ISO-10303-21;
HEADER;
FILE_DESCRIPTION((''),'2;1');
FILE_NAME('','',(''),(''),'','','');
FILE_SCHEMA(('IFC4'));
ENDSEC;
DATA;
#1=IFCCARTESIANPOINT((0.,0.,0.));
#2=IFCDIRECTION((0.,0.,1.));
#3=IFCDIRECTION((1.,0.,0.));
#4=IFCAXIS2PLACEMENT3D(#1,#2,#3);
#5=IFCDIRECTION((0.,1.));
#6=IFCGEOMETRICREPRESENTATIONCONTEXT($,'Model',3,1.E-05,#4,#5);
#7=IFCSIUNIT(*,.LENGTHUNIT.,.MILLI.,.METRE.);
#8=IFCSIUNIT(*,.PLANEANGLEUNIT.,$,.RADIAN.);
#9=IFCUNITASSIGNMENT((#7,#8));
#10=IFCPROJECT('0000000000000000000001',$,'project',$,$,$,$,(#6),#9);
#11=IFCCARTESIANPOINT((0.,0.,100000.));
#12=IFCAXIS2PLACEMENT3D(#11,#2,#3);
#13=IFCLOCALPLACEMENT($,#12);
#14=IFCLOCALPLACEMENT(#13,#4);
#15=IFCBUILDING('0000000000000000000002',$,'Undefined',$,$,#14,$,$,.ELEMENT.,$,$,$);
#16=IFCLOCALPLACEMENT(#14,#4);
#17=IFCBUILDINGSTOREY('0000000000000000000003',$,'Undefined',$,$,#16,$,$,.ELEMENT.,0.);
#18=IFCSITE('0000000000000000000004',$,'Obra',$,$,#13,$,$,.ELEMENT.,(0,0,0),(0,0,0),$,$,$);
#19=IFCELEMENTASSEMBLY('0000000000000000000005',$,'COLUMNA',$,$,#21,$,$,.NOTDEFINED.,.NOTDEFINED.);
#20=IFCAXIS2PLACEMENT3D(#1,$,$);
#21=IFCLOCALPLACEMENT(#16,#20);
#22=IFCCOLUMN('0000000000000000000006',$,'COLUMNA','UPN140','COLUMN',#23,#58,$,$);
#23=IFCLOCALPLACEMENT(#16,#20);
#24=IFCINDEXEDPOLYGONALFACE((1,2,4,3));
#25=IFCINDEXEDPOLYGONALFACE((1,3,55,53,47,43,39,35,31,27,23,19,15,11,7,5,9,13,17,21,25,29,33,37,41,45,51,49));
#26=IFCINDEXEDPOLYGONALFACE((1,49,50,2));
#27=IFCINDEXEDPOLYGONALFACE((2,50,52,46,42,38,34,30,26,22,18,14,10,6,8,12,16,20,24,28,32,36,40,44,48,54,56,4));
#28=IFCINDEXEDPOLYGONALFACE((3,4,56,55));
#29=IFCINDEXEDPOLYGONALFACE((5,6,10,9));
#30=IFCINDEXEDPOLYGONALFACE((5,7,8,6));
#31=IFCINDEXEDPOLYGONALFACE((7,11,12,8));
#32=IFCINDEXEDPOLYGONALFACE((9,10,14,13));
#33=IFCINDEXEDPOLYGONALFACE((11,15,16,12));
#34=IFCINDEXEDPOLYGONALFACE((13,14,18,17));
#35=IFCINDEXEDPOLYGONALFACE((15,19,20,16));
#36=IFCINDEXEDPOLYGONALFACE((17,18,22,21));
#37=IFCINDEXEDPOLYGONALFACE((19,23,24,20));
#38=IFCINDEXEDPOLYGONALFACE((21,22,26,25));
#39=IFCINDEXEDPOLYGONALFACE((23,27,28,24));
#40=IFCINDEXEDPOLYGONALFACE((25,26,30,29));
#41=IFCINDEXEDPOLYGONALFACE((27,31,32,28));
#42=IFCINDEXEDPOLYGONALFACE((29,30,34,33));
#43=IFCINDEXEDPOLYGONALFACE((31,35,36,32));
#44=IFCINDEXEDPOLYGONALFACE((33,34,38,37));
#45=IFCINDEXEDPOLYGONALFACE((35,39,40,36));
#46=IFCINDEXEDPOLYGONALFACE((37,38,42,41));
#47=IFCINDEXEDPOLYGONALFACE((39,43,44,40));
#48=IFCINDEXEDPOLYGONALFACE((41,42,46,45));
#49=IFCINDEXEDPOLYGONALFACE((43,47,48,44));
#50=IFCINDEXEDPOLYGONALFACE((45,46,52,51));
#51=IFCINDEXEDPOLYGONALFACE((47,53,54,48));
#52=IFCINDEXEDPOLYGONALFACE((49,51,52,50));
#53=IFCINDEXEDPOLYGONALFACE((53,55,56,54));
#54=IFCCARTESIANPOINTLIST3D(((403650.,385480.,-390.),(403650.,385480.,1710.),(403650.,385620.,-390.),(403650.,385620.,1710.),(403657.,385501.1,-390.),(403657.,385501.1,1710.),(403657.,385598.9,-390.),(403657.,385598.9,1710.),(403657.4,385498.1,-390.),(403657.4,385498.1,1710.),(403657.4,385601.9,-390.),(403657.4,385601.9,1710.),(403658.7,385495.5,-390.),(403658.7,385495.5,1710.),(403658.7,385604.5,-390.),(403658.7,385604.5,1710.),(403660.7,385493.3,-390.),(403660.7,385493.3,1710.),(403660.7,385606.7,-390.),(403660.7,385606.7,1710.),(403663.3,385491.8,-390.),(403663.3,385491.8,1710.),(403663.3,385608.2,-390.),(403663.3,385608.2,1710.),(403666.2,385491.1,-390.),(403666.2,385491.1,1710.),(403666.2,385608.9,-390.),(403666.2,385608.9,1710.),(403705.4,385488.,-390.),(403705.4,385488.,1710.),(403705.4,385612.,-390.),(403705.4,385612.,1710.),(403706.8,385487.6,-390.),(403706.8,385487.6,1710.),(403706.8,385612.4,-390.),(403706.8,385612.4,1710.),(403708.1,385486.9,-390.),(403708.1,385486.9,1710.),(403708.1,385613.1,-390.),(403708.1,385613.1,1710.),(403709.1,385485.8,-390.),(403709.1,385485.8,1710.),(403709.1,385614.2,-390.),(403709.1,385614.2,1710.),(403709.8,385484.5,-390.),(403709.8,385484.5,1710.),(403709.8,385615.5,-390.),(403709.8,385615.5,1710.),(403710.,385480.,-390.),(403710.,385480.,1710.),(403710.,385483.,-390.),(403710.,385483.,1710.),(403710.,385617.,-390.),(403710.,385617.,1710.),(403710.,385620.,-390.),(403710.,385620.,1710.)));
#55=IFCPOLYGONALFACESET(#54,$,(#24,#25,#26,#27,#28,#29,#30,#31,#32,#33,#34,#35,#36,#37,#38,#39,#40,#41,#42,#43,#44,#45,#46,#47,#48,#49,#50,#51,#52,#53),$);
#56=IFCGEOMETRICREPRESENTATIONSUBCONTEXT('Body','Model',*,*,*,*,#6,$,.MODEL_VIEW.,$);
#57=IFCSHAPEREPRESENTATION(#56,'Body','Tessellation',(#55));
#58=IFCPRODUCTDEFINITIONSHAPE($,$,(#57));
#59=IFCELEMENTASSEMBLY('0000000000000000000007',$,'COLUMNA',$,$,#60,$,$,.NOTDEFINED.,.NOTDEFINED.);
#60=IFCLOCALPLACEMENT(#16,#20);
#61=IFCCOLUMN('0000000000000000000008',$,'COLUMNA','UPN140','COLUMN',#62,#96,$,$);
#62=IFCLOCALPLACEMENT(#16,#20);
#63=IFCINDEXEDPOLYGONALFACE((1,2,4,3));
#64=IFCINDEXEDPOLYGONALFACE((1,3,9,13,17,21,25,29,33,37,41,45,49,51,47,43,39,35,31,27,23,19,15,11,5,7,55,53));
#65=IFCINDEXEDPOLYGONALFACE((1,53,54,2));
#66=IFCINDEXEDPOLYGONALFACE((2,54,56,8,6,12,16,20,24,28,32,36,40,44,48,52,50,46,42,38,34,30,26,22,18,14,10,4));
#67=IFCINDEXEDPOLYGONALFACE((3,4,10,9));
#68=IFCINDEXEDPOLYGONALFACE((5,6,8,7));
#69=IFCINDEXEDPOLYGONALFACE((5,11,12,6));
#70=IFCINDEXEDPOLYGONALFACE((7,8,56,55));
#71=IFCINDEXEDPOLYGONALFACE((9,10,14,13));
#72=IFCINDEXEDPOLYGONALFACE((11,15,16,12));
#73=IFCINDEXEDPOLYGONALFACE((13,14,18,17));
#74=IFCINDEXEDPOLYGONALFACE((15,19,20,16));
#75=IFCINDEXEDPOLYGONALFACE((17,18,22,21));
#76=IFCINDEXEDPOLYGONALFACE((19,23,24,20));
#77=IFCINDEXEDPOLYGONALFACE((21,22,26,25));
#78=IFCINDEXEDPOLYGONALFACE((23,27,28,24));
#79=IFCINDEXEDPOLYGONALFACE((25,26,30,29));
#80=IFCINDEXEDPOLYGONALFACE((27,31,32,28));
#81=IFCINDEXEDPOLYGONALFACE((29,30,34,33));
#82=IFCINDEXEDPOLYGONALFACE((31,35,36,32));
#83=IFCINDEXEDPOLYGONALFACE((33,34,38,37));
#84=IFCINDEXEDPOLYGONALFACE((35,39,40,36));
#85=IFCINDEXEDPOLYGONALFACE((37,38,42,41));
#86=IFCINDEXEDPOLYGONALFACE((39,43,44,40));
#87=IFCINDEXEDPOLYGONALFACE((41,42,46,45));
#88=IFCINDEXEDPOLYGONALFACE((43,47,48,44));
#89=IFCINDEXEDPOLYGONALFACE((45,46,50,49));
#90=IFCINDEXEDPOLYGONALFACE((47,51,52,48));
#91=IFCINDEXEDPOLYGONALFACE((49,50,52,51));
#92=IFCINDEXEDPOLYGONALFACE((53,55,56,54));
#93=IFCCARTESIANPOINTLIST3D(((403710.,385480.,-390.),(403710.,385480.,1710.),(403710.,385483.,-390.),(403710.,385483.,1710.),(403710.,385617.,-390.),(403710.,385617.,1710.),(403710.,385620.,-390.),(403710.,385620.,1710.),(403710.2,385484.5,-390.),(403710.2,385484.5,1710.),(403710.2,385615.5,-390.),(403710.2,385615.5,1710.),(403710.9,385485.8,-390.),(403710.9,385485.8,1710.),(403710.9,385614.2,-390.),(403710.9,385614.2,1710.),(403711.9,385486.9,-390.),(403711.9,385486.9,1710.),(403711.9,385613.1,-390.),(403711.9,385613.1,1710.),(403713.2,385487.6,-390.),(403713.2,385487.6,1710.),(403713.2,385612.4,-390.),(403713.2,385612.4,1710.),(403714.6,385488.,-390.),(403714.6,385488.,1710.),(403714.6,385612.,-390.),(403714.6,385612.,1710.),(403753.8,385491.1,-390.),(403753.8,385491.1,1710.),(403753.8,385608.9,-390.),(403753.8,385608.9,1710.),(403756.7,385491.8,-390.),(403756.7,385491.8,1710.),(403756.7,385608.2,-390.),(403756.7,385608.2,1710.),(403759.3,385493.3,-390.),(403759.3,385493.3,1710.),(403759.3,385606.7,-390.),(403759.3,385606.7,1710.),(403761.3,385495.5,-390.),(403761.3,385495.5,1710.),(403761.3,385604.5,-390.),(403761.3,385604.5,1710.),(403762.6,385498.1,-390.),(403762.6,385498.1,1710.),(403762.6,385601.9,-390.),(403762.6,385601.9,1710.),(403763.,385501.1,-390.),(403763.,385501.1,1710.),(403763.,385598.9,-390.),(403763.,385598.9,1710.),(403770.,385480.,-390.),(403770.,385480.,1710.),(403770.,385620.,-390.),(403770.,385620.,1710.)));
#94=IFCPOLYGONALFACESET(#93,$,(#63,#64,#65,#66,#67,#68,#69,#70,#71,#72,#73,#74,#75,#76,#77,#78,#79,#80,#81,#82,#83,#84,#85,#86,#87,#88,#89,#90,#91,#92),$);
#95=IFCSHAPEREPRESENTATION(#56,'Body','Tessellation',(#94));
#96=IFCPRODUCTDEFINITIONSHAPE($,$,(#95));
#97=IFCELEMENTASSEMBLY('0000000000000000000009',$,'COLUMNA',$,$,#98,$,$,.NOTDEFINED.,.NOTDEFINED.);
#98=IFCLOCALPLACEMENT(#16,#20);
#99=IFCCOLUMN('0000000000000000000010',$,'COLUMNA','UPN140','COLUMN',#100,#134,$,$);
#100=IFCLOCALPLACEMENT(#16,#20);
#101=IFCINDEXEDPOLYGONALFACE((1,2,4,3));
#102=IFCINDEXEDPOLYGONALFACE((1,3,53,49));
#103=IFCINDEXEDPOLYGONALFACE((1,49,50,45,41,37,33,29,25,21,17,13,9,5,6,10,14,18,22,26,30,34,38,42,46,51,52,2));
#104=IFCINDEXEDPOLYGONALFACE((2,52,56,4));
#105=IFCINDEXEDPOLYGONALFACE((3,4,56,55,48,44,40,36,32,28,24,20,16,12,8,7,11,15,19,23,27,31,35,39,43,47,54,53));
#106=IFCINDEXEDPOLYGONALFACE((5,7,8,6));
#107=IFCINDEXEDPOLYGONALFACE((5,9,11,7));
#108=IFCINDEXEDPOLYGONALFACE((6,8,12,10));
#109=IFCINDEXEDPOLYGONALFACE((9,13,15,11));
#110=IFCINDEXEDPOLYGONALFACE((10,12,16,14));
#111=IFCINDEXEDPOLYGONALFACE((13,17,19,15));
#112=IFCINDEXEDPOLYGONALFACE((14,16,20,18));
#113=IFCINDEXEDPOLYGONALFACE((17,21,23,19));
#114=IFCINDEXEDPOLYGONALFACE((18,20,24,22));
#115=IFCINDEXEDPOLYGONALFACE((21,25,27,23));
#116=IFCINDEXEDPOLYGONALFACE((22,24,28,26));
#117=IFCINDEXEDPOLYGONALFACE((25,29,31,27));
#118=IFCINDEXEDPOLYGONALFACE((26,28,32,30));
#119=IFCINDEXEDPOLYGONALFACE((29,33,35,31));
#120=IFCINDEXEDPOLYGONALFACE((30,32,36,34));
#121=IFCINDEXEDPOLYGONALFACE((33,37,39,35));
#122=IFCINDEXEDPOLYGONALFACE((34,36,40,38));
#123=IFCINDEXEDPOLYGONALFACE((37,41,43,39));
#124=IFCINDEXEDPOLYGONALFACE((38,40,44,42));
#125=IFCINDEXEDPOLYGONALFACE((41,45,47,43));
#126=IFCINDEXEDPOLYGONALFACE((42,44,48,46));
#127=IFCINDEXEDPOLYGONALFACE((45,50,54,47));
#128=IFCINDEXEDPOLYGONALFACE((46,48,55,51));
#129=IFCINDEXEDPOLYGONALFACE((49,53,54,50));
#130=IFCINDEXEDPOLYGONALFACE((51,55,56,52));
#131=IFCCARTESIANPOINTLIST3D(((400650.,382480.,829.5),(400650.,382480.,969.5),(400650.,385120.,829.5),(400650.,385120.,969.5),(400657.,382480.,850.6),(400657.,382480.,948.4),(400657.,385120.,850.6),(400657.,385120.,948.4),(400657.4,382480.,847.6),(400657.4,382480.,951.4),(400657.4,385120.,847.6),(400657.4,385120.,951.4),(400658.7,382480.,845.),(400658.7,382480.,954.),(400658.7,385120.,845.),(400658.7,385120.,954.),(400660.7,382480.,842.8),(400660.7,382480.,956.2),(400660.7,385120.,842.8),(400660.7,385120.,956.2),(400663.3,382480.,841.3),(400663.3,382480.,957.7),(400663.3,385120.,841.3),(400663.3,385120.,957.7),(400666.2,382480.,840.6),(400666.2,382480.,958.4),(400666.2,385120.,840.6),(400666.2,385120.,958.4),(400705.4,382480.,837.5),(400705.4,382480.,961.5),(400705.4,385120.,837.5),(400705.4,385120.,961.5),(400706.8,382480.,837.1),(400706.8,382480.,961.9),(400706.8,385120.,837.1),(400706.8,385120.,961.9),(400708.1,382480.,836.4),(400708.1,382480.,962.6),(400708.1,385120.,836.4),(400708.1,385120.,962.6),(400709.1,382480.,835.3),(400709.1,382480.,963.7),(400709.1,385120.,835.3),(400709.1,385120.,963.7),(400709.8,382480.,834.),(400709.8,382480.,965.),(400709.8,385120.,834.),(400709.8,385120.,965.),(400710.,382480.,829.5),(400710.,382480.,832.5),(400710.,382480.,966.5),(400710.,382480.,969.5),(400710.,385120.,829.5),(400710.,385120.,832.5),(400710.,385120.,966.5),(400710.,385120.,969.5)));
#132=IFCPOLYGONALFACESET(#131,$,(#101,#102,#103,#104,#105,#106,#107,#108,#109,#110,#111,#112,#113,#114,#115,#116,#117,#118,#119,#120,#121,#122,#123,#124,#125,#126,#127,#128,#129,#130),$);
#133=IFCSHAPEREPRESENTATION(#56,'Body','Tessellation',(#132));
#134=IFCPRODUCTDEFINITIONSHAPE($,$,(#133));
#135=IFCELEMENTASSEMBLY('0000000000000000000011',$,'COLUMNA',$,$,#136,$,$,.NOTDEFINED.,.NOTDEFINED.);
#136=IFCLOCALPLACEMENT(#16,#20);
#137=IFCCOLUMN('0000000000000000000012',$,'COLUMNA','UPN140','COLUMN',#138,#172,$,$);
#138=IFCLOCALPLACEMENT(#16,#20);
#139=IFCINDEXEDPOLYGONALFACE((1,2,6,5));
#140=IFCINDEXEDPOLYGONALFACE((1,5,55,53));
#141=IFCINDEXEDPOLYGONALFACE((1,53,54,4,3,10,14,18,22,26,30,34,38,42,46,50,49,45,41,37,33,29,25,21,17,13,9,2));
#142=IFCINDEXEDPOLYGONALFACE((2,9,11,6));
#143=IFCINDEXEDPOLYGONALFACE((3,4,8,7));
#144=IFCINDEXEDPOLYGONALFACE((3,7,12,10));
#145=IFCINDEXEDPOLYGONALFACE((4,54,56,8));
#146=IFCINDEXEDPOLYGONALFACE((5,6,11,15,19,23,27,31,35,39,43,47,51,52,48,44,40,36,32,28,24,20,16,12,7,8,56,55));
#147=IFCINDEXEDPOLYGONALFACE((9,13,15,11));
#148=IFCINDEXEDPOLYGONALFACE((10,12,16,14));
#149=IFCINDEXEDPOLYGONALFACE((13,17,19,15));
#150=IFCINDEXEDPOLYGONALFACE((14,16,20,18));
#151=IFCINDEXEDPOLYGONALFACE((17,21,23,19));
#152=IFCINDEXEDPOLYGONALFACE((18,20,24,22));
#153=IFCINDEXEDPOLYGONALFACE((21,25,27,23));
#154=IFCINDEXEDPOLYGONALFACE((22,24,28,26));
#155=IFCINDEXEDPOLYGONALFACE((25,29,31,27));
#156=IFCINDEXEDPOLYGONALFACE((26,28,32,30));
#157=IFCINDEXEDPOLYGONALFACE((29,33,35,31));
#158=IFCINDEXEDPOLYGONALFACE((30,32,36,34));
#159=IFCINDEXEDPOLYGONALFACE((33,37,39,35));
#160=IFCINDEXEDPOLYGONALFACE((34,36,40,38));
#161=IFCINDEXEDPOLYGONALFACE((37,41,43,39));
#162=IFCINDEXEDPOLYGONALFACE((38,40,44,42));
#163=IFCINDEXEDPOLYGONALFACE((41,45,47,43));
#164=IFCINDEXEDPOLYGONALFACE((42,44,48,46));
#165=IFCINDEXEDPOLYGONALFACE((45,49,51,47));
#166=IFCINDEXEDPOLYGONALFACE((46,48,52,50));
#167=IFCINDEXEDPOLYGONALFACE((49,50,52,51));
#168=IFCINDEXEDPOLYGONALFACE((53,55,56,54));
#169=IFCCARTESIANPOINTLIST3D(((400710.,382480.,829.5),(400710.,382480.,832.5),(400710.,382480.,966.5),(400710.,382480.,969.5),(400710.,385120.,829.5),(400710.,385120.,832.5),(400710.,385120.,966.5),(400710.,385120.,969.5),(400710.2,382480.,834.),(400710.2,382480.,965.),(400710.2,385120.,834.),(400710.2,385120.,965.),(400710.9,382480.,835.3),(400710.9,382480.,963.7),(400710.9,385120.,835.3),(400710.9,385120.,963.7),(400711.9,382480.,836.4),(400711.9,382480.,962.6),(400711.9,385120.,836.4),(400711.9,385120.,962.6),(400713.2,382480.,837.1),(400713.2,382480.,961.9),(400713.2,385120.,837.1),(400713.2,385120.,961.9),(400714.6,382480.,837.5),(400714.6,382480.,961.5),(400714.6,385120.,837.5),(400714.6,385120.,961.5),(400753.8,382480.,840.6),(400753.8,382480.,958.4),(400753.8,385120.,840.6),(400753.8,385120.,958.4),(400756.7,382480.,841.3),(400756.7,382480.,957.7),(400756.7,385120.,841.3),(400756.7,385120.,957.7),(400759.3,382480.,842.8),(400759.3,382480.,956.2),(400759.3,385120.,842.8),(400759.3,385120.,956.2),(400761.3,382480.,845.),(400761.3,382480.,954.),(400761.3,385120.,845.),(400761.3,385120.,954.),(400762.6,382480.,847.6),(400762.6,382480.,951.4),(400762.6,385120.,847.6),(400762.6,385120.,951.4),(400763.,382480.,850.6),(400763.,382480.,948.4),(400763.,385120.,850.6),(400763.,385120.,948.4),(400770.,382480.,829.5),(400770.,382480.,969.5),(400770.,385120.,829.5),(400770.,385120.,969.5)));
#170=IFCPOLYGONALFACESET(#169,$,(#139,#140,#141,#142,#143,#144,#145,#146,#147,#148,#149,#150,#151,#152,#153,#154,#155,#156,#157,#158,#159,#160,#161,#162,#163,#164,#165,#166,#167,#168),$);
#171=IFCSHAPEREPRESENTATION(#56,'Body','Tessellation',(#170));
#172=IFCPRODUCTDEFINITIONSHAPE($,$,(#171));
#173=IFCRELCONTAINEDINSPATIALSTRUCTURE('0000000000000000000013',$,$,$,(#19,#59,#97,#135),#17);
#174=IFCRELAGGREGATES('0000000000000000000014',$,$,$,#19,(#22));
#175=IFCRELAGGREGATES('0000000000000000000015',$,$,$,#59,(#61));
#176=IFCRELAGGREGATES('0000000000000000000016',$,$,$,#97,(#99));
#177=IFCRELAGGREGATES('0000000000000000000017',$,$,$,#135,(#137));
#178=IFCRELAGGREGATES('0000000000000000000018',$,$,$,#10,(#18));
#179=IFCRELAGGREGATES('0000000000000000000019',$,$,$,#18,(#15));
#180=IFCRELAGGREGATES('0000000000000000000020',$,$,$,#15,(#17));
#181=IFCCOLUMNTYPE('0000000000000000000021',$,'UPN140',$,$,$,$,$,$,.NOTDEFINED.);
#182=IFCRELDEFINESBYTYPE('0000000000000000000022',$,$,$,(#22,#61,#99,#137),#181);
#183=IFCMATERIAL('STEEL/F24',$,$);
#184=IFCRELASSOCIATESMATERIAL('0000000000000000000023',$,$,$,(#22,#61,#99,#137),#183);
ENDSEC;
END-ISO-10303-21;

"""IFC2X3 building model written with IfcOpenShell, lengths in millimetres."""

from ifc_helpers import new_model, si_unit, direction, frame, origin_with_axes, origin_2d_with_axis, place, context, subcontext, project, spatial, u_section, extrude, material, type_object, element, aggregate, save


model = new_model("IFC2X3")

# Units and contexts
model_context = context("Model", 3, precision=1e-05, world=origin_with_axes(), true_north=direction((0.0, 1.0)))
body_context = subcontext(model_context, "Body", "Model", "MODEL_VIEW")
ifc_project = project(units=[si_unit("LENGTHUNIT", "METRE", prefix="MILLI"), si_unit("PLANEANGLEUNIT", "RADIAN")], contexts=[model_context])

# Site, building, storey
site_placement = place(None, frame((0.0, 0.0, 100000.0), z_axis=(0.0, 0.0, 1.0), x_axis=(1.0, 0.0, 0.0)))
site = spatial("IfcSite", under=ifc_project, at=site_placement, Name="Obra", CompositionType="ELEMENT", RefLatitude=(0, 0, 0), RefLongitude=(0, 0, 0))
building_placement = place(site_placement, origin_with_axes())
building = spatial("IfcBuilding", under=site, at=building_placement, Name="Undefined", CompositionType="ELEMENT")
storey_placement = place(building_placement, origin_with_axes())
storey = spatial("IfcBuildingStorey", under=building, at=storey_placement, Name="Undefined", CompositionType="ELEMENT", Elevation=0.0)

# Element assemblies, columns
ifc_material_1 = material(Name="STEEL/F24")
column_type_1 = type_object("IfcColumnType", Name="UPN140", PredefinedType="NOTDEFINED")
assembly_1_placement = place(storey_placement, origin_with_axes())
assembly_1 = element("IfcElementAssembly", 1, at=assembly_1_placement, inside=storey, Name="COLUMNA", AssemblyPlace="NOTDEFINED", PredefinedType="NOTDEFINED")
column_1_placement = place(assembly_1_placement, frame((403680.0, 385550.0, -390.0), z_axis=(0.0, 0.0, 1.0), x_axis=(0.0, -1.0, 0.0)))
column_1 = element("IfcColumn", 2, at=column_1_placement, type_object=column_type_1, material=ifc_material_1, Name="COLUMNA", Description="UPN140", ObjectType="COLUMN", context=body_context, shape_type="SweptSolid", body=[
    extrude(u_section(Depth=140.0, FlangeWidth=60.0, WebThickness=7.0, FlangeThickness=10.0, FilletRadius=10.0, EdgeRadius=5.0, FlangeSlope=0.07983, at=origin_2d_with_axis()), frame((0.0, 0.0, 2100.0), z_axis=(0.0, 0.0, -1.0), x_axis=(0.0, 1.0, 0.0)), (0.0, 0.0, 1.0), 2100.0),
])
aggregate(assembly_1, [column_1])
assembly_2_placement = place(storey_placement, origin_with_axes())
assembly_2 = element("IfcElementAssembly", 3, at=assembly_2_placement, inside=storey, Name="COLUMNA", AssemblyPlace="NOTDEFINED", PredefinedType="NOTDEFINED")
column_2_placement = place(assembly_2_placement, frame((403740.0, 385550.0, -390.0), z_axis=(0.0, 0.0, 1.0), x_axis=(0.0, 1.0, 0.0)))
column_2 = element("IfcColumn", 4, at=column_2_placement, type_object=column_type_1, material=ifc_material_1, Name="COLUMNA", Description="UPN140", ObjectType="COLUMN", context=body_context, shape_type="SweptSolid", body=[
    extrude(u_section(Depth=140.0, FlangeWidth=60.0, WebThickness=7.0, FlangeThickness=10.0, FilletRadius=10.0, EdgeRadius=5.0, FlangeSlope=0.07983, at=origin_2d_with_axis()), frame((0.0, 0.0, 2100.0), z_axis=(0.0, 0.0, -1.0), x_axis=(0.0, 1.0, 0.0)), (0.0, 0.0, 1.0), 2100.0),
])
aggregate(assembly_2, [column_2])
assembly_3_placement = place(storey_placement, origin_with_axes())
assembly_3 = element("IfcElementAssembly", 5, at=assembly_3_placement, inside=storey, Name="COLUMNA", AssemblyPlace="NOTDEFINED", PredefinedType="NOTDEFINED")
column_3_placement = place(assembly_3_placement, frame((400680.0, 385120.0, 899.5), z_axis=(0.0, -1.0, 0.0), x_axis=(0.0, 0.0, -1.0)))
column_3 = element("IfcColumn", 6, at=column_3_placement, type_object=column_type_1, material=ifc_material_1, Name="COLUMNA", Description="UPN140", ObjectType="COLUMN", context=body_context, shape_type="SweptSolid", body=[
    extrude(u_section(Depth=140.0, FlangeWidth=60.0, WebThickness=7.0, FlangeThickness=10.0, FilletRadius=10.0, EdgeRadius=5.0, FlangeSlope=0.07983, at=origin_2d_with_axis()), frame((0.0, 0.0, 2640.0), z_axis=(0.0, 0.0, -1.0), x_axis=(0.0, 1.0, 0.0)), (0.0, 0.0, 1.0), 2640.0),
])
aggregate(assembly_3, [column_3])
assembly_4_placement = place(storey_placement, origin_with_axes())
assembly_4 = element("IfcElementAssembly", 7, at=assembly_4_placement, inside=storey, Name="COLUMNA", AssemblyPlace="NOTDEFINED", PredefinedType="NOTDEFINED")
column_4_placement = place(assembly_4_placement, frame((400740.0, 385120.0, 899.5), z_axis=(0.0, -1.0, 0.0), x_axis=(0.0, 0.0, 1.0)))
column_4 = element("IfcColumn", 8, at=column_4_placement, type_object=column_type_1, material=ifc_material_1, Name="COLUMNA", Description="UPN140", ObjectType="COLUMN", context=body_context, shape_type="SweptSolid", body=[
    extrude(u_section(Depth=140.0, FlangeWidth=60.0, WebThickness=7.0, FlangeThickness=10.0, FilletRadius=10.0, EdgeRadius=5.0, FlangeSlope=0.07983, at=origin_2d_with_axis()), frame((0.0, 0.0, 2640.0), z_axis=(0.0, 0.0, -1.0), x_axis=(0.0, 1.0, 0.0)), (0.0, 0.0, 1.0), 2640.0),
])
aggregate(assembly_4, [column_4])

save(model, "model.ifc")
